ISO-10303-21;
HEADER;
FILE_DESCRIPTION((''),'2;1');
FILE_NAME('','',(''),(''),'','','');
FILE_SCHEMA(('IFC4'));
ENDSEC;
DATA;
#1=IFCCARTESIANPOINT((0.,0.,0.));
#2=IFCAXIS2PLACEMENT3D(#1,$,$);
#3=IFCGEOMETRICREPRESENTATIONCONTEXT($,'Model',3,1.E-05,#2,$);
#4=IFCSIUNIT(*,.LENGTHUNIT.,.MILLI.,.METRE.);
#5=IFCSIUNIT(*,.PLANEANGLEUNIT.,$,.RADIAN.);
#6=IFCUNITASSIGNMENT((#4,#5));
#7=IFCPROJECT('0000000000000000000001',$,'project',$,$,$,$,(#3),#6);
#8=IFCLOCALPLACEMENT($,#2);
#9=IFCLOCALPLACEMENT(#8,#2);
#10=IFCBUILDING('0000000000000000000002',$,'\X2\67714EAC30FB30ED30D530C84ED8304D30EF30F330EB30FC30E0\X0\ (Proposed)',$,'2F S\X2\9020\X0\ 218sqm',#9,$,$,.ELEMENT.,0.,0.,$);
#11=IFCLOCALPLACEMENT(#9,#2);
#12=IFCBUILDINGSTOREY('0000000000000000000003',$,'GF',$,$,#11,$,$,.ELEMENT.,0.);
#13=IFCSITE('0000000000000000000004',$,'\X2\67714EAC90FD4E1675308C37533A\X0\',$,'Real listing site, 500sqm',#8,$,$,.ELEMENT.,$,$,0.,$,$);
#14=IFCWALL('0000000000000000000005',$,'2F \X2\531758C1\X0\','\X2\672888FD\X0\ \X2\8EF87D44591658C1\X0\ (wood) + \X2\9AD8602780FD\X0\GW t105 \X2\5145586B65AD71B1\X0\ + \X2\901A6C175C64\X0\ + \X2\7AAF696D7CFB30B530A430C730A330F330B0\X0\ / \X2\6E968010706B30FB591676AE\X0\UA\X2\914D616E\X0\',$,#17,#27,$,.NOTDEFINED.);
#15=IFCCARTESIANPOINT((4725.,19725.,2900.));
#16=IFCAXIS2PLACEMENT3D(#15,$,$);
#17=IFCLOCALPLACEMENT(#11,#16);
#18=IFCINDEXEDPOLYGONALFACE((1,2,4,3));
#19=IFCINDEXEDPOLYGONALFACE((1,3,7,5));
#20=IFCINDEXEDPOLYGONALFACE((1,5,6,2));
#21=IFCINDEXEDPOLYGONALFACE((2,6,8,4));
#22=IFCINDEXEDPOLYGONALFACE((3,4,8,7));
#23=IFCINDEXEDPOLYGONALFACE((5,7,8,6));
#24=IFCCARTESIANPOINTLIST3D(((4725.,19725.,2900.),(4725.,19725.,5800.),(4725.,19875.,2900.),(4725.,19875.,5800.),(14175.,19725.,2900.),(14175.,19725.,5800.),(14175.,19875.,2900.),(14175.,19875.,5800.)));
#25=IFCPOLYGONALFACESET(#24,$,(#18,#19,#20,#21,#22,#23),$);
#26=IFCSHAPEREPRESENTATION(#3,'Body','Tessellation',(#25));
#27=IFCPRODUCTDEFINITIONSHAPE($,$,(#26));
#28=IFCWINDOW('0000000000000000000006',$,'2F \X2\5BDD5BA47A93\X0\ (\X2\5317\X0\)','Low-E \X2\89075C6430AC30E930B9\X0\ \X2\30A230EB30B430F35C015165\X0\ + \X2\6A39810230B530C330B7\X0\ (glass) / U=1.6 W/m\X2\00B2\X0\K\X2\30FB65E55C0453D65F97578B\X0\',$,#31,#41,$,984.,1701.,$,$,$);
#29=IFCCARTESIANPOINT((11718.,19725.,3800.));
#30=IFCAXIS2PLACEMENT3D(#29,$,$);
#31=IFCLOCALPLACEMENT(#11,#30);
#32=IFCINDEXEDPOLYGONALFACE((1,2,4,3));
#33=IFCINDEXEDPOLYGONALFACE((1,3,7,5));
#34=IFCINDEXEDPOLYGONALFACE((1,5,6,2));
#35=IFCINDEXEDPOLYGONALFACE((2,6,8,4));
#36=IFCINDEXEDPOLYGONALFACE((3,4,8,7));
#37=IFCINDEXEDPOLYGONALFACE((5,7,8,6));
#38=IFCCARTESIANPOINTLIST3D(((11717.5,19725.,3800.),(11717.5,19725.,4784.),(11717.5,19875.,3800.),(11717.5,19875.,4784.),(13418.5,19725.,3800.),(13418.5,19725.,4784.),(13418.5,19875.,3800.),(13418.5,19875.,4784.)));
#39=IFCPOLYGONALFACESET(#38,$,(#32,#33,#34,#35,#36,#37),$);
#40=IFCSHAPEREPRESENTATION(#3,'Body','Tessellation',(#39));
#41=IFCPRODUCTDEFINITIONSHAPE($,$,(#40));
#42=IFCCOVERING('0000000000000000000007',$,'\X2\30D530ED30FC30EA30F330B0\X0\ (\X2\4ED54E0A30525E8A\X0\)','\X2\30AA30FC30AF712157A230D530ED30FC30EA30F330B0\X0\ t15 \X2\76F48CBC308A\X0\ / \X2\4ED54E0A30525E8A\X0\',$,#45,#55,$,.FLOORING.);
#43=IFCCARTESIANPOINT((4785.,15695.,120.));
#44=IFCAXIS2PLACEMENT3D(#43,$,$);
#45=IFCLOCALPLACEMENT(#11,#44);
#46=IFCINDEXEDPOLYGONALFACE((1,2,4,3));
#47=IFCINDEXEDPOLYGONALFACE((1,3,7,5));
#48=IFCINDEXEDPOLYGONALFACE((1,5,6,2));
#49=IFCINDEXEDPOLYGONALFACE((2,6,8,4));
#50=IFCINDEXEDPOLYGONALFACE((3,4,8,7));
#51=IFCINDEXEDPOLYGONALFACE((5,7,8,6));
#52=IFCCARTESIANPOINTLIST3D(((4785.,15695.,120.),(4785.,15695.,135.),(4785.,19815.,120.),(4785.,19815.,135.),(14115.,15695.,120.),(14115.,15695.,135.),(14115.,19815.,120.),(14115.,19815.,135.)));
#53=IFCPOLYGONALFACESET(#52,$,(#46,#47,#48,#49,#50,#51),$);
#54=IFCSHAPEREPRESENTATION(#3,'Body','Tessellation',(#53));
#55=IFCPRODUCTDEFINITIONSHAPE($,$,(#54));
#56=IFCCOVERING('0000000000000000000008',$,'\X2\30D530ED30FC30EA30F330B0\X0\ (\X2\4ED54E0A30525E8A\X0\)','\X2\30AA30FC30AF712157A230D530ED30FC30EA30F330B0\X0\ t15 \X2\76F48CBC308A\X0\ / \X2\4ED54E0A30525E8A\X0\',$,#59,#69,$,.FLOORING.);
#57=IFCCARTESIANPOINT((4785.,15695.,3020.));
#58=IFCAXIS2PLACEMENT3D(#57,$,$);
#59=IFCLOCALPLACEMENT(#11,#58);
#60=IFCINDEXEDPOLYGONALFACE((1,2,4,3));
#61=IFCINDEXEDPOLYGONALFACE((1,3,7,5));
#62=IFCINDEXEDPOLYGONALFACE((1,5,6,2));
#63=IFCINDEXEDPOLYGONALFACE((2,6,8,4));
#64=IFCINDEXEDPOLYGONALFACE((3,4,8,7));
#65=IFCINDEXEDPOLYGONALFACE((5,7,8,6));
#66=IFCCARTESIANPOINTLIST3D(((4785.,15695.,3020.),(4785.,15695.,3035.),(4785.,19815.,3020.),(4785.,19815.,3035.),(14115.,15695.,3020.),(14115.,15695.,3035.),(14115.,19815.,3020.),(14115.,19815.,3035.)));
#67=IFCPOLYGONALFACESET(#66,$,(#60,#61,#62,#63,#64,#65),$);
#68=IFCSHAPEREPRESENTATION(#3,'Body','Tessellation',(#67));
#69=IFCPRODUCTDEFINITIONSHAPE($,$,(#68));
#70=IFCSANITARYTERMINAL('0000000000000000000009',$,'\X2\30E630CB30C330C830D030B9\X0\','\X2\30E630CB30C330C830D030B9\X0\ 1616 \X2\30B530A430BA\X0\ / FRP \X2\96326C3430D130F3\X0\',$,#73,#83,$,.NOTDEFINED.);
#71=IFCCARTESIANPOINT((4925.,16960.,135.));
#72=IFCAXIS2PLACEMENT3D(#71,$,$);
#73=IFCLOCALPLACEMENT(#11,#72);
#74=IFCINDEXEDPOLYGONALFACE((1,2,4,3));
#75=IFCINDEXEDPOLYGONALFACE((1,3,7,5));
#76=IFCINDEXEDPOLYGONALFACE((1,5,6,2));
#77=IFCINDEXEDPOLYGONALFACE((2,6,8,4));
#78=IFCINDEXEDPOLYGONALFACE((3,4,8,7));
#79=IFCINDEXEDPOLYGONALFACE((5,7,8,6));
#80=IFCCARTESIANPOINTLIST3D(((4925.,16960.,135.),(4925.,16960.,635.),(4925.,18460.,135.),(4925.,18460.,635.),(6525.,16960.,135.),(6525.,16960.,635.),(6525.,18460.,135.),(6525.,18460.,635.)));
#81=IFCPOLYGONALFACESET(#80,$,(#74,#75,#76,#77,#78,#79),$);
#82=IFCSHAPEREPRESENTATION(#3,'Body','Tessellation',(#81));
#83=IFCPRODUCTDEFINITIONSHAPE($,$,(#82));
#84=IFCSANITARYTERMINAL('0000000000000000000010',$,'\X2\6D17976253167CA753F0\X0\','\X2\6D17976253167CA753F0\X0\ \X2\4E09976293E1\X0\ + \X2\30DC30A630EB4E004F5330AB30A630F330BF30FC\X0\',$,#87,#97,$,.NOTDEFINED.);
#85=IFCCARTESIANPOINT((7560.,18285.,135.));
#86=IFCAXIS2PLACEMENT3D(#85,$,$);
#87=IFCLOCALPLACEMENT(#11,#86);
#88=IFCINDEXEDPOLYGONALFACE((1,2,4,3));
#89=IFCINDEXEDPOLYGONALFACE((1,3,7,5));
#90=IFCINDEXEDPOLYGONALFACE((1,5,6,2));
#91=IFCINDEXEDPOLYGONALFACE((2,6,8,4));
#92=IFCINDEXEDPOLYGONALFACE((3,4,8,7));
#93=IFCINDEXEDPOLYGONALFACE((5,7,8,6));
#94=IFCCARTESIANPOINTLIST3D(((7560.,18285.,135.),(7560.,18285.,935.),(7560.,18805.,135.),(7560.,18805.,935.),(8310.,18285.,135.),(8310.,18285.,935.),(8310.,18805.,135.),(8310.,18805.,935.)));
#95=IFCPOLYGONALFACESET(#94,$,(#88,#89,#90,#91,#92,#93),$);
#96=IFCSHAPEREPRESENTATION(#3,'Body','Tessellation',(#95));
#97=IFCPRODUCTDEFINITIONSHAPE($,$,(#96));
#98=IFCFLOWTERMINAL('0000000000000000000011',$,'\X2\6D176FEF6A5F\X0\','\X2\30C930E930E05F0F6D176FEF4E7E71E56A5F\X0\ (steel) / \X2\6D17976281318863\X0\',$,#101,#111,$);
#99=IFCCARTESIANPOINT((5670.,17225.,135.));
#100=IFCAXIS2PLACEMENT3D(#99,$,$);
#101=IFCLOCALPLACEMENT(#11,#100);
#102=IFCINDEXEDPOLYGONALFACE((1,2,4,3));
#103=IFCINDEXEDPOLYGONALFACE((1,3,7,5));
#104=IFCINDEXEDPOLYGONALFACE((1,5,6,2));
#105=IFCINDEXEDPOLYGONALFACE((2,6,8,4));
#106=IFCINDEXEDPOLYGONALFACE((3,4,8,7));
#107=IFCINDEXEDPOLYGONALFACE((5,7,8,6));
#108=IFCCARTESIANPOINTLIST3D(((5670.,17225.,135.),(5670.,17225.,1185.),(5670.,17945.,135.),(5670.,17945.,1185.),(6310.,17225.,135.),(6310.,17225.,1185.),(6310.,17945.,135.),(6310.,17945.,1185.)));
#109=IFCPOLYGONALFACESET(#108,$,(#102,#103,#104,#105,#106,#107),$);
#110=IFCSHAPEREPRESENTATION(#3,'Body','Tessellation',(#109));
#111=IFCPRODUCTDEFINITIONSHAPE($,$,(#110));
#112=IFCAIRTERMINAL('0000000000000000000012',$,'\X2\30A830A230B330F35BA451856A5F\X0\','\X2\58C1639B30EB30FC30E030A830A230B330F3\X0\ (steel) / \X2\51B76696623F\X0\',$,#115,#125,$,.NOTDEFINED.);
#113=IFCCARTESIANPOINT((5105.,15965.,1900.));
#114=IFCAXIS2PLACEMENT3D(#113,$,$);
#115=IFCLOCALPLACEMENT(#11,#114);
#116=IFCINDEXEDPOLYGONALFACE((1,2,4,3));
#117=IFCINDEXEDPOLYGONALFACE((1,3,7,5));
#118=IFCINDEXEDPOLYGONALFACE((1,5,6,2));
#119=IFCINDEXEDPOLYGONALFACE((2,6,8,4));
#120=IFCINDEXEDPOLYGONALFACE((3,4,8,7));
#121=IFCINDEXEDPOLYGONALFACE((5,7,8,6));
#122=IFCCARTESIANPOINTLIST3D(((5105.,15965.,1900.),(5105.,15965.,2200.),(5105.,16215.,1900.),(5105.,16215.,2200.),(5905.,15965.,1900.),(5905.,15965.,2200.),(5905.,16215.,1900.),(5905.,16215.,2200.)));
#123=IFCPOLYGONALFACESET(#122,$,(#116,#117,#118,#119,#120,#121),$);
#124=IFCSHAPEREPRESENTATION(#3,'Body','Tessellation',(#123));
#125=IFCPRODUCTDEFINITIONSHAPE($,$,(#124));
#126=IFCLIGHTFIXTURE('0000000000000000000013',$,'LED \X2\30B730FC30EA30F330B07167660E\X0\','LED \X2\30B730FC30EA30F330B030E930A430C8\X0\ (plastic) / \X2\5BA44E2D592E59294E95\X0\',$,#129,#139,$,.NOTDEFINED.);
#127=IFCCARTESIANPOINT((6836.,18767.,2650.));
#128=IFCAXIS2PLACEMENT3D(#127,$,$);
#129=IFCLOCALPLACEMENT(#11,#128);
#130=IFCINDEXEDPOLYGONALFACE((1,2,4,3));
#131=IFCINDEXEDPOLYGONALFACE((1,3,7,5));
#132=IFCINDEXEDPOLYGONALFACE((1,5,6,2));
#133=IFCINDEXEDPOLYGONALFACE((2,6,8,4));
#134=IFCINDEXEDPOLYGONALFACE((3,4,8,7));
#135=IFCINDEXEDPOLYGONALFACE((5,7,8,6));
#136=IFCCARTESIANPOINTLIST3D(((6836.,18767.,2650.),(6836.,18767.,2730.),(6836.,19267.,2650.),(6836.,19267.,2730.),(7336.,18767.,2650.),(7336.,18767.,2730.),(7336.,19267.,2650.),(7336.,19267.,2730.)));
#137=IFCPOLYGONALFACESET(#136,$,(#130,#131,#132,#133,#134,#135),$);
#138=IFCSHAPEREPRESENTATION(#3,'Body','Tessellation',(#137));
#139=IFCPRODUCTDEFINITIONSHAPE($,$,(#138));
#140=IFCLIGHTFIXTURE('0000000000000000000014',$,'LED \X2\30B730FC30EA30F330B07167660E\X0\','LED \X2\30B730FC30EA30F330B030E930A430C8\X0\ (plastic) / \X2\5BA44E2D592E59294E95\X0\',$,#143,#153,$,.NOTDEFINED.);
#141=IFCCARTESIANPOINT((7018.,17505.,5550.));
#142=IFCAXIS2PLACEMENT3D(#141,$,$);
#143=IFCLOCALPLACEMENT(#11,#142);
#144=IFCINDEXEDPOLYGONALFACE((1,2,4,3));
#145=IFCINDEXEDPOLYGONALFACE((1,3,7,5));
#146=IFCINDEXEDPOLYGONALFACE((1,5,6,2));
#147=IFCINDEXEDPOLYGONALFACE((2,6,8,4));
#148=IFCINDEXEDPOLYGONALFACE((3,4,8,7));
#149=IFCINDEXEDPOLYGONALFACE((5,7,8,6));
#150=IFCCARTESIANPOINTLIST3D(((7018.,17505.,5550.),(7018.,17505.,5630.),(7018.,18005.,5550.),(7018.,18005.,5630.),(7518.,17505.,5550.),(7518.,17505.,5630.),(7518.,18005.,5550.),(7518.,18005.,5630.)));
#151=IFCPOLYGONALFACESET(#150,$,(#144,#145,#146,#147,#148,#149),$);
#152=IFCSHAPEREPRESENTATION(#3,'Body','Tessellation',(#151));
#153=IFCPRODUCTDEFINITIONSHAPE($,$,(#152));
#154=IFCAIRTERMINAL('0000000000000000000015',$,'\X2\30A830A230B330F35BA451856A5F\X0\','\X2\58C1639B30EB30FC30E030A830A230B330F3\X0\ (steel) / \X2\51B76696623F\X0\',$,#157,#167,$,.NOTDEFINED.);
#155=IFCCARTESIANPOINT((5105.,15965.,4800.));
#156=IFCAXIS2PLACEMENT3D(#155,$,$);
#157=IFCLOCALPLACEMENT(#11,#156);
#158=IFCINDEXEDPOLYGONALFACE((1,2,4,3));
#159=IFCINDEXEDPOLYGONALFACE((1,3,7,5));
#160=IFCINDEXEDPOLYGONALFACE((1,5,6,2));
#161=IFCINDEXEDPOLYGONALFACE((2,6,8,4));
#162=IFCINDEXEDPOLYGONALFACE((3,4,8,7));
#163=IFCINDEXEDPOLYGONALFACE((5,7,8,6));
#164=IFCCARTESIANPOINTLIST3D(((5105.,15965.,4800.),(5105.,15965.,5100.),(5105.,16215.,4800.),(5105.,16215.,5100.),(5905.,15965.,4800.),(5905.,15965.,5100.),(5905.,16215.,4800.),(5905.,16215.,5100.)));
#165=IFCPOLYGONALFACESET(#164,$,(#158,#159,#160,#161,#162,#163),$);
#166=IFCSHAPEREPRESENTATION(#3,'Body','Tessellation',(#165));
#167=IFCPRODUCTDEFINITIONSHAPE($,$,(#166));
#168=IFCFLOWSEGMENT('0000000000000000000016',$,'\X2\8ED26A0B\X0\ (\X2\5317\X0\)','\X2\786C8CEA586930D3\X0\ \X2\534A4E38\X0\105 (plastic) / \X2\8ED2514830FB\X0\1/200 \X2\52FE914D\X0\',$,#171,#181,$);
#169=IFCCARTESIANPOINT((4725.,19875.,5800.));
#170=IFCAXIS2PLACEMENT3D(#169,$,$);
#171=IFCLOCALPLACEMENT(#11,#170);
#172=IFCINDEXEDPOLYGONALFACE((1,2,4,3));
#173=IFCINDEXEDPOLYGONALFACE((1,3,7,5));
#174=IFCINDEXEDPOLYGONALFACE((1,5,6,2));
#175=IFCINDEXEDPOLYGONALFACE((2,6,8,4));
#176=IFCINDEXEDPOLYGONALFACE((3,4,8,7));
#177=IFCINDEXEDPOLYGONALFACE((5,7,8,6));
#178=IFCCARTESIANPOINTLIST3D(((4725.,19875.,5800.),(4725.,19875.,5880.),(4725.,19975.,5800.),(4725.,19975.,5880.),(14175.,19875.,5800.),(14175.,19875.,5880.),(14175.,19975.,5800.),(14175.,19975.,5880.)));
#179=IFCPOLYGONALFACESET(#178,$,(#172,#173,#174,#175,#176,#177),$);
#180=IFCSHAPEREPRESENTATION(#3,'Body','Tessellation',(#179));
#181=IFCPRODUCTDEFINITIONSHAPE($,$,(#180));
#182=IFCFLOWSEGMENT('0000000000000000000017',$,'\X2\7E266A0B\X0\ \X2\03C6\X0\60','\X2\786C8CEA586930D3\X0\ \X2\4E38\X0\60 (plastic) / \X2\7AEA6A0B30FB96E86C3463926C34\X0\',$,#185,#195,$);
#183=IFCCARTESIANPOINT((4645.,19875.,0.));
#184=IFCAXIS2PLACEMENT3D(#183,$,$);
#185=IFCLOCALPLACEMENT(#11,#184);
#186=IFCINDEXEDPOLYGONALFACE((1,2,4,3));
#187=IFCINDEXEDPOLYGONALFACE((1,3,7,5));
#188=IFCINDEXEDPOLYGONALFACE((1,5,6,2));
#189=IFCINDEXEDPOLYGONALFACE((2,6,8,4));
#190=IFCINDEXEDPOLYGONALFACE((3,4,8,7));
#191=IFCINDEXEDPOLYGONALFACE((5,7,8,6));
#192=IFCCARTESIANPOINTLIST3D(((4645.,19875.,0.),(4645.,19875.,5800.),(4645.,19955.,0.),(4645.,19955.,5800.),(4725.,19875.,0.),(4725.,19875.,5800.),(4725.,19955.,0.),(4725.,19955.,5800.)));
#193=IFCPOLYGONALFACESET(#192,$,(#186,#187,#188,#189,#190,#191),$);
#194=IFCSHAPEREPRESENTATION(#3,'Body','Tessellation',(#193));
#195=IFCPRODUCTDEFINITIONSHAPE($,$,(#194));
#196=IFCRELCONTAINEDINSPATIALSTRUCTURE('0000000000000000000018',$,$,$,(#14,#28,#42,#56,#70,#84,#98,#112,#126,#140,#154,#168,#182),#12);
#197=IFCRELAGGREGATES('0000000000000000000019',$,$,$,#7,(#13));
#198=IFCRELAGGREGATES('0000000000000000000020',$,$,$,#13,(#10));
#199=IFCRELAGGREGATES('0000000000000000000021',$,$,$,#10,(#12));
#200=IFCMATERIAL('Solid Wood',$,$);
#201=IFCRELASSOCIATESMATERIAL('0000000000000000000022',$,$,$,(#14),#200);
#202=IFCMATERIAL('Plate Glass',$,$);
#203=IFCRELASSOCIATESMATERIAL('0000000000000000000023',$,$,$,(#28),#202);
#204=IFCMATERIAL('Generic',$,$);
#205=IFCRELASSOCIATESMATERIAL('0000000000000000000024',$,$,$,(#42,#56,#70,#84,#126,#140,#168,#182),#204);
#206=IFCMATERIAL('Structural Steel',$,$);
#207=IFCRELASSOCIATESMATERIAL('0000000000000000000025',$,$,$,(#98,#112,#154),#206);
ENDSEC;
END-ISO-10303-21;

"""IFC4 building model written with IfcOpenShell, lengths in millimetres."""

from ifc_helpers import new_model, si_unit, frame, frame_2d, origin, place, context, project, spatial, rectangle, extrude, material, element, fill, save


model = new_model("IFC4")

# Units and contexts
model_context = context("Model", 3, precision=1e-05, world=origin())
ifc_project = project(units=[si_unit("LENGTHUNIT", "METRE", prefix="MILLI"), si_unit("PLANEANGLEUNIT", "RADIAN")], contexts=[model_context])

# Site, building, storey
site_placement = place(None, origin())
site = spatial("IfcSite", under=ifc_project, at=site_placement, Name="東京都世田谷区", ObjectType="Real listing site, 500sqm", CompositionType="ELEMENT", RefElevation=0.0)
building_placement = place(site_placement, origin())
building = spatial("IfcBuilding", under=site, at=building_placement, Name="東京・ロフト付きワンルーム (Proposed)", ObjectType="2F S造 218sqm", CompositionType="ELEMENT", ElevationOfRefHeight=0.0, ElevationOfTerrain=0.0)
storey_placement = place(building_placement, origin())
storey = spatial("IfcBuildingStorey", under=building, at=storey_placement, Name="GF", CompositionType="ELEMENT", Elevation=0.0)

# Shared definitions
ifc_material_1 = material(Name="Solid Wood")

# Shared definitions
ifc_material_2 = material(Name="Plate Glass")

# Wall, opening, window
wall_1_placement = place(storey_placement, frame((4725.0, 19725.0, 2900.0)))
wall_1 = element("IfcWall", 1, at=wall_1_placement, inside=storey, material=ifc_material_1, Name="2F 北壁", Description="木製 軸組外壁 (wood) + 高性能GW t105 充填断熱 + 通気層 + 窯業系サイディング / 準耐火・外皮UA配慮", PredefinedType="NOTDEFINED", context=model_context, shape_type="SweptSolid", body=[
    extrude(rectangle(XDim=9450.0, YDim=150.0, at=frame_2d((4725.0, 75.0))), frame((4725.0, 19725.0, 2900.0)), (0.0, 0.0, 1.0), 2900.0),
])
opening_1_placement = place(storey_placement, frame((11718.0, 19725.0, 3800.0)))
opening_1 = element("IfcOpeningElement", 2, at=opening_1_placement, cuts=wall_1, PredefinedType="NOTDEFINED", context=model_context, shape_type="SweptSolid", body=[
    extrude(rectangle(XDim=1701.0, YDim=150.0, at=frame_2d((850.0, 75.0))), frame((11718.0, 19725.0, 3800.0)), (0.0, 0.0, 1.0), 984.0),
])
window_1_placement = place(storey_placement, frame((11718.0, 19725.0, 3800.0)))
window_1 = element("IfcWindow", 3, at=window_1_placement, inside=storey, material=ifc_material_2, Name="2F 寝室窓 (北)", Description="Low-E 複層ガラス アルゴン封入 + 樹脂サッシ (glass) / U=1.6 W/m²K・日射取得型", OverallHeight=984.0, OverallWidth=1701.0, context=model_context, shape_type="SweptSolid", body=[
    extrude(rectangle(XDim=1701.0, YDim=150.0, at=frame_2d((850.0, 75.0))), frame((11718.0, 19725.0, 3800.0)), (0.0, 0.0, 1.0), 984.0),
])
fill(opening_1, window_1)

# Coverings
ifc_material_3 = material(Name="Generic")
covering_1_placement = place(storey_placement, frame((4785.0, 15695.0, 120.0)))
element("IfcCovering", 4, at=covering_1_placement, inside=storey, material=ifc_material_3, Name="フローリング (仕上げ床)", Description="オーク無垢フローリング t15 直貼り / 仕上げ床", PredefinedType="FLOORING", context=model_context, shape_type="SweptSolid", body=[
    extrude(rectangle(XDim=9330.0, YDim=4120.0, at=frame_2d((4665.0, 2060.0))), frame((4785.0, 15695.0, 120.0)), (0.0, 0.0, 1.0), 15.0),
])
covering_2_placement = place(storey_placement, frame((4785.0, 15695.0, 3020.0)))
element("IfcCovering", 5, at=covering_2_placement, inside=storey, material=ifc_material_3, Name="フローリング (仕上げ床)", Description="オーク無垢フローリング t15 直貼り / 仕上げ床", PredefinedType="FLOORING", context=model_context, shape_type="SweptSolid", body=[
    extrude(rectangle(XDim=9330.0, YDim=4120.0, at=frame_2d((4665.0, 2060.0))), frame((4785.0, 15695.0, 3020.0)), (0.0, 0.0, 1.0), 15.0),
])

# Sanitary terminals
sanitary_terminal_1_placement = place(storey_placement, frame((4925.0, 16960.0, 135.0)))
element("IfcSanitaryTerminal", 6, at=sanitary_terminal_1_placement, inside=storey, material=ifc_material_3, Name="ユニットバス", Description="ユニットバス 1616 サイズ / FRP 防水パン", PredefinedType="NOTDEFINED", context=model_context, shape_type="SweptSolid", body=[
    extrude(rectangle(XDim=1600.0, YDim=1500.0, at=frame_2d((800.0, 750.0))), frame((4925.0, 16960.0, 135.0)), (0.0, 0.0, 1.0), 500.0),
])
sanitary_terminal_2_placement = place(storey_placement, frame((7560.0, 18285.0, 135.0)))
element("IfcSanitaryTerminal", 7, at=sanitary_terminal_2_placement, inside=storey, material=ifc_material_3, Name="洗面化粧台", Description="洗面化粧台 三面鏡 + ボウル一体カウンター", PredefinedType="NOTDEFINED", context=model_context, shape_type="SweptSolid", body=[
    extrude(rectangle(XDim=750.0, YDim=520.0, at=frame_2d((375.0, 260.0))), frame((7560.0, 18285.0, 135.0)), (0.0, 0.0, 1.0), 800.0),
])

# Flow terminal
ifc_material_4 = material(Name="Structural Steel")
flow_terminal_placement = place(storey_placement, frame((5670.0, 17225.0, 135.0)))
element("IfcFlowTerminal", 8, at=flow_terminal_placement, inside=storey, material=ifc_material_4, Name="洗濯機", Description="ドラム式洗濯乾燥機 (steel) / 洗面脱衣", context=model_context, shape_type="SweptSolid", body=[
    extrude(rectangle(XDim=640.0, YDim=720.0, at=frame_2d((320.0, 360.0))), frame((5670.0, 17225.0, 135.0)), (0.0, 0.0, 1.0), 1050.0),
])

# Air terminal
air_terminal_1_placement = place(storey_placement, frame((5105.0, 15965.0, 1900.0)))
element("IfcAirTerminal", 9, at=air_terminal_1_placement, inside=storey, material=ifc_material_4, Name="エアコン室内機", Description="壁掛ルームエアコン (steel) / 冷暖房", PredefinedType="NOTDEFINED", context=model_context, shape_type="SweptSolid", body=[
    extrude(rectangle(XDim=800.0, YDim=250.0, at=frame_2d((400.0, 125.0))), frame((5105.0, 15965.0, 1900.0)), (0.0, 0.0, 1.0), 300.0),
])

# Light fixtures
light_fixture_1_placement = place(storey_placement, frame((6836.0, 18767.0, 2650.0)))
element("IfcLightFixture", 10, at=light_fixture_1_placement, inside=storey, material=ifc_material_3, Name="LED シーリング照明", Description="LED シーリングライト (plastic) / 室中央天井", PredefinedType="NOTDEFINED", context=model_context, shape_type="SweptSolid", body=[
    extrude(rectangle(XDim=500.0, YDim=500.0, at=frame_2d((250.0, 250.0))), frame((6836.0, 18767.0, 2650.0)), (0.0, 0.0, 1.0), 80.0),
])
light_fixture_2_placement = place(storey_placement, frame((7018.0, 17505.0, 5550.0)))
element("IfcLightFixture", 11, at=light_fixture_2_placement, inside=storey, material=ifc_material_3, Name="LED シーリング照明", Description="LED シーリングライト (plastic) / 室中央天井", PredefinedType="NOTDEFINED", context=model_context, shape_type="SweptSolid", body=[
    extrude(rectangle(XDim=500.0, YDim=500.0, at=frame_2d((250.0, 250.0))), frame((7018.0, 17505.0, 5550.0)), (0.0, 0.0, 1.0), 80.0),
])

# Air terminal
air_terminal_2_placement = place(storey_placement, frame((5105.0, 15965.0, 4800.0)))
element("IfcAirTerminal", 12, at=air_terminal_2_placement, inside=storey, material=ifc_material_4, Name="エアコン室内機", Description="壁掛ルームエアコン (steel) / 冷暖房", PredefinedType="NOTDEFINED", context=model_context, shape_type="SweptSolid", body=[
    extrude(rectangle(XDim=800.0, YDim=250.0, at=frame_2d((400.0, 125.0))), frame((5105.0, 15965.0, 4800.0)), (0.0, 0.0, 1.0), 300.0),
])

# Flow segments
flow_segment_1_placement = place(storey_placement, frame((4725.0, 19875.0, 5800.0)))
element("IfcFlowSegment", 13, at=flow_segment_1_placement, inside=storey, material=ifc_material_3, Name="軒樋 (北)", Description="硬質塩ビ 半丸105 (plastic) / 軒先・1/200 勾配", context=model_context, shape_type="SweptSolid", body=[
    extrude(rectangle(XDim=9450.0, YDim=100.0, at=frame_2d((4725.0, 50.0))), frame((4725.0, 19875.0, 5800.0)), (0.0, 0.0, 1.0), 80.0),
])
flow_segment_2_placement = place(storey_placement, frame((4645.0, 19875.0, 0.0)))
element("IfcFlowSegment", 14, at=flow_segment_2_placement, inside=storey, material=ifc_material_3, Name="縦樋 φ60", Description="硬質塩ビ 丸60 (plastic) / 竪樋・雨水排水", context=model_context, shape_type="SweptSolid", body=[
    extrude(rectangle(XDim=80.0, YDim=80.0, at=frame_2d((40.0, 40.0))), frame((4645.0, 19875.0, 0.0)), (0.0, 0.0, 1.0), 5800.0),
])

save(model, "model.ifc")
